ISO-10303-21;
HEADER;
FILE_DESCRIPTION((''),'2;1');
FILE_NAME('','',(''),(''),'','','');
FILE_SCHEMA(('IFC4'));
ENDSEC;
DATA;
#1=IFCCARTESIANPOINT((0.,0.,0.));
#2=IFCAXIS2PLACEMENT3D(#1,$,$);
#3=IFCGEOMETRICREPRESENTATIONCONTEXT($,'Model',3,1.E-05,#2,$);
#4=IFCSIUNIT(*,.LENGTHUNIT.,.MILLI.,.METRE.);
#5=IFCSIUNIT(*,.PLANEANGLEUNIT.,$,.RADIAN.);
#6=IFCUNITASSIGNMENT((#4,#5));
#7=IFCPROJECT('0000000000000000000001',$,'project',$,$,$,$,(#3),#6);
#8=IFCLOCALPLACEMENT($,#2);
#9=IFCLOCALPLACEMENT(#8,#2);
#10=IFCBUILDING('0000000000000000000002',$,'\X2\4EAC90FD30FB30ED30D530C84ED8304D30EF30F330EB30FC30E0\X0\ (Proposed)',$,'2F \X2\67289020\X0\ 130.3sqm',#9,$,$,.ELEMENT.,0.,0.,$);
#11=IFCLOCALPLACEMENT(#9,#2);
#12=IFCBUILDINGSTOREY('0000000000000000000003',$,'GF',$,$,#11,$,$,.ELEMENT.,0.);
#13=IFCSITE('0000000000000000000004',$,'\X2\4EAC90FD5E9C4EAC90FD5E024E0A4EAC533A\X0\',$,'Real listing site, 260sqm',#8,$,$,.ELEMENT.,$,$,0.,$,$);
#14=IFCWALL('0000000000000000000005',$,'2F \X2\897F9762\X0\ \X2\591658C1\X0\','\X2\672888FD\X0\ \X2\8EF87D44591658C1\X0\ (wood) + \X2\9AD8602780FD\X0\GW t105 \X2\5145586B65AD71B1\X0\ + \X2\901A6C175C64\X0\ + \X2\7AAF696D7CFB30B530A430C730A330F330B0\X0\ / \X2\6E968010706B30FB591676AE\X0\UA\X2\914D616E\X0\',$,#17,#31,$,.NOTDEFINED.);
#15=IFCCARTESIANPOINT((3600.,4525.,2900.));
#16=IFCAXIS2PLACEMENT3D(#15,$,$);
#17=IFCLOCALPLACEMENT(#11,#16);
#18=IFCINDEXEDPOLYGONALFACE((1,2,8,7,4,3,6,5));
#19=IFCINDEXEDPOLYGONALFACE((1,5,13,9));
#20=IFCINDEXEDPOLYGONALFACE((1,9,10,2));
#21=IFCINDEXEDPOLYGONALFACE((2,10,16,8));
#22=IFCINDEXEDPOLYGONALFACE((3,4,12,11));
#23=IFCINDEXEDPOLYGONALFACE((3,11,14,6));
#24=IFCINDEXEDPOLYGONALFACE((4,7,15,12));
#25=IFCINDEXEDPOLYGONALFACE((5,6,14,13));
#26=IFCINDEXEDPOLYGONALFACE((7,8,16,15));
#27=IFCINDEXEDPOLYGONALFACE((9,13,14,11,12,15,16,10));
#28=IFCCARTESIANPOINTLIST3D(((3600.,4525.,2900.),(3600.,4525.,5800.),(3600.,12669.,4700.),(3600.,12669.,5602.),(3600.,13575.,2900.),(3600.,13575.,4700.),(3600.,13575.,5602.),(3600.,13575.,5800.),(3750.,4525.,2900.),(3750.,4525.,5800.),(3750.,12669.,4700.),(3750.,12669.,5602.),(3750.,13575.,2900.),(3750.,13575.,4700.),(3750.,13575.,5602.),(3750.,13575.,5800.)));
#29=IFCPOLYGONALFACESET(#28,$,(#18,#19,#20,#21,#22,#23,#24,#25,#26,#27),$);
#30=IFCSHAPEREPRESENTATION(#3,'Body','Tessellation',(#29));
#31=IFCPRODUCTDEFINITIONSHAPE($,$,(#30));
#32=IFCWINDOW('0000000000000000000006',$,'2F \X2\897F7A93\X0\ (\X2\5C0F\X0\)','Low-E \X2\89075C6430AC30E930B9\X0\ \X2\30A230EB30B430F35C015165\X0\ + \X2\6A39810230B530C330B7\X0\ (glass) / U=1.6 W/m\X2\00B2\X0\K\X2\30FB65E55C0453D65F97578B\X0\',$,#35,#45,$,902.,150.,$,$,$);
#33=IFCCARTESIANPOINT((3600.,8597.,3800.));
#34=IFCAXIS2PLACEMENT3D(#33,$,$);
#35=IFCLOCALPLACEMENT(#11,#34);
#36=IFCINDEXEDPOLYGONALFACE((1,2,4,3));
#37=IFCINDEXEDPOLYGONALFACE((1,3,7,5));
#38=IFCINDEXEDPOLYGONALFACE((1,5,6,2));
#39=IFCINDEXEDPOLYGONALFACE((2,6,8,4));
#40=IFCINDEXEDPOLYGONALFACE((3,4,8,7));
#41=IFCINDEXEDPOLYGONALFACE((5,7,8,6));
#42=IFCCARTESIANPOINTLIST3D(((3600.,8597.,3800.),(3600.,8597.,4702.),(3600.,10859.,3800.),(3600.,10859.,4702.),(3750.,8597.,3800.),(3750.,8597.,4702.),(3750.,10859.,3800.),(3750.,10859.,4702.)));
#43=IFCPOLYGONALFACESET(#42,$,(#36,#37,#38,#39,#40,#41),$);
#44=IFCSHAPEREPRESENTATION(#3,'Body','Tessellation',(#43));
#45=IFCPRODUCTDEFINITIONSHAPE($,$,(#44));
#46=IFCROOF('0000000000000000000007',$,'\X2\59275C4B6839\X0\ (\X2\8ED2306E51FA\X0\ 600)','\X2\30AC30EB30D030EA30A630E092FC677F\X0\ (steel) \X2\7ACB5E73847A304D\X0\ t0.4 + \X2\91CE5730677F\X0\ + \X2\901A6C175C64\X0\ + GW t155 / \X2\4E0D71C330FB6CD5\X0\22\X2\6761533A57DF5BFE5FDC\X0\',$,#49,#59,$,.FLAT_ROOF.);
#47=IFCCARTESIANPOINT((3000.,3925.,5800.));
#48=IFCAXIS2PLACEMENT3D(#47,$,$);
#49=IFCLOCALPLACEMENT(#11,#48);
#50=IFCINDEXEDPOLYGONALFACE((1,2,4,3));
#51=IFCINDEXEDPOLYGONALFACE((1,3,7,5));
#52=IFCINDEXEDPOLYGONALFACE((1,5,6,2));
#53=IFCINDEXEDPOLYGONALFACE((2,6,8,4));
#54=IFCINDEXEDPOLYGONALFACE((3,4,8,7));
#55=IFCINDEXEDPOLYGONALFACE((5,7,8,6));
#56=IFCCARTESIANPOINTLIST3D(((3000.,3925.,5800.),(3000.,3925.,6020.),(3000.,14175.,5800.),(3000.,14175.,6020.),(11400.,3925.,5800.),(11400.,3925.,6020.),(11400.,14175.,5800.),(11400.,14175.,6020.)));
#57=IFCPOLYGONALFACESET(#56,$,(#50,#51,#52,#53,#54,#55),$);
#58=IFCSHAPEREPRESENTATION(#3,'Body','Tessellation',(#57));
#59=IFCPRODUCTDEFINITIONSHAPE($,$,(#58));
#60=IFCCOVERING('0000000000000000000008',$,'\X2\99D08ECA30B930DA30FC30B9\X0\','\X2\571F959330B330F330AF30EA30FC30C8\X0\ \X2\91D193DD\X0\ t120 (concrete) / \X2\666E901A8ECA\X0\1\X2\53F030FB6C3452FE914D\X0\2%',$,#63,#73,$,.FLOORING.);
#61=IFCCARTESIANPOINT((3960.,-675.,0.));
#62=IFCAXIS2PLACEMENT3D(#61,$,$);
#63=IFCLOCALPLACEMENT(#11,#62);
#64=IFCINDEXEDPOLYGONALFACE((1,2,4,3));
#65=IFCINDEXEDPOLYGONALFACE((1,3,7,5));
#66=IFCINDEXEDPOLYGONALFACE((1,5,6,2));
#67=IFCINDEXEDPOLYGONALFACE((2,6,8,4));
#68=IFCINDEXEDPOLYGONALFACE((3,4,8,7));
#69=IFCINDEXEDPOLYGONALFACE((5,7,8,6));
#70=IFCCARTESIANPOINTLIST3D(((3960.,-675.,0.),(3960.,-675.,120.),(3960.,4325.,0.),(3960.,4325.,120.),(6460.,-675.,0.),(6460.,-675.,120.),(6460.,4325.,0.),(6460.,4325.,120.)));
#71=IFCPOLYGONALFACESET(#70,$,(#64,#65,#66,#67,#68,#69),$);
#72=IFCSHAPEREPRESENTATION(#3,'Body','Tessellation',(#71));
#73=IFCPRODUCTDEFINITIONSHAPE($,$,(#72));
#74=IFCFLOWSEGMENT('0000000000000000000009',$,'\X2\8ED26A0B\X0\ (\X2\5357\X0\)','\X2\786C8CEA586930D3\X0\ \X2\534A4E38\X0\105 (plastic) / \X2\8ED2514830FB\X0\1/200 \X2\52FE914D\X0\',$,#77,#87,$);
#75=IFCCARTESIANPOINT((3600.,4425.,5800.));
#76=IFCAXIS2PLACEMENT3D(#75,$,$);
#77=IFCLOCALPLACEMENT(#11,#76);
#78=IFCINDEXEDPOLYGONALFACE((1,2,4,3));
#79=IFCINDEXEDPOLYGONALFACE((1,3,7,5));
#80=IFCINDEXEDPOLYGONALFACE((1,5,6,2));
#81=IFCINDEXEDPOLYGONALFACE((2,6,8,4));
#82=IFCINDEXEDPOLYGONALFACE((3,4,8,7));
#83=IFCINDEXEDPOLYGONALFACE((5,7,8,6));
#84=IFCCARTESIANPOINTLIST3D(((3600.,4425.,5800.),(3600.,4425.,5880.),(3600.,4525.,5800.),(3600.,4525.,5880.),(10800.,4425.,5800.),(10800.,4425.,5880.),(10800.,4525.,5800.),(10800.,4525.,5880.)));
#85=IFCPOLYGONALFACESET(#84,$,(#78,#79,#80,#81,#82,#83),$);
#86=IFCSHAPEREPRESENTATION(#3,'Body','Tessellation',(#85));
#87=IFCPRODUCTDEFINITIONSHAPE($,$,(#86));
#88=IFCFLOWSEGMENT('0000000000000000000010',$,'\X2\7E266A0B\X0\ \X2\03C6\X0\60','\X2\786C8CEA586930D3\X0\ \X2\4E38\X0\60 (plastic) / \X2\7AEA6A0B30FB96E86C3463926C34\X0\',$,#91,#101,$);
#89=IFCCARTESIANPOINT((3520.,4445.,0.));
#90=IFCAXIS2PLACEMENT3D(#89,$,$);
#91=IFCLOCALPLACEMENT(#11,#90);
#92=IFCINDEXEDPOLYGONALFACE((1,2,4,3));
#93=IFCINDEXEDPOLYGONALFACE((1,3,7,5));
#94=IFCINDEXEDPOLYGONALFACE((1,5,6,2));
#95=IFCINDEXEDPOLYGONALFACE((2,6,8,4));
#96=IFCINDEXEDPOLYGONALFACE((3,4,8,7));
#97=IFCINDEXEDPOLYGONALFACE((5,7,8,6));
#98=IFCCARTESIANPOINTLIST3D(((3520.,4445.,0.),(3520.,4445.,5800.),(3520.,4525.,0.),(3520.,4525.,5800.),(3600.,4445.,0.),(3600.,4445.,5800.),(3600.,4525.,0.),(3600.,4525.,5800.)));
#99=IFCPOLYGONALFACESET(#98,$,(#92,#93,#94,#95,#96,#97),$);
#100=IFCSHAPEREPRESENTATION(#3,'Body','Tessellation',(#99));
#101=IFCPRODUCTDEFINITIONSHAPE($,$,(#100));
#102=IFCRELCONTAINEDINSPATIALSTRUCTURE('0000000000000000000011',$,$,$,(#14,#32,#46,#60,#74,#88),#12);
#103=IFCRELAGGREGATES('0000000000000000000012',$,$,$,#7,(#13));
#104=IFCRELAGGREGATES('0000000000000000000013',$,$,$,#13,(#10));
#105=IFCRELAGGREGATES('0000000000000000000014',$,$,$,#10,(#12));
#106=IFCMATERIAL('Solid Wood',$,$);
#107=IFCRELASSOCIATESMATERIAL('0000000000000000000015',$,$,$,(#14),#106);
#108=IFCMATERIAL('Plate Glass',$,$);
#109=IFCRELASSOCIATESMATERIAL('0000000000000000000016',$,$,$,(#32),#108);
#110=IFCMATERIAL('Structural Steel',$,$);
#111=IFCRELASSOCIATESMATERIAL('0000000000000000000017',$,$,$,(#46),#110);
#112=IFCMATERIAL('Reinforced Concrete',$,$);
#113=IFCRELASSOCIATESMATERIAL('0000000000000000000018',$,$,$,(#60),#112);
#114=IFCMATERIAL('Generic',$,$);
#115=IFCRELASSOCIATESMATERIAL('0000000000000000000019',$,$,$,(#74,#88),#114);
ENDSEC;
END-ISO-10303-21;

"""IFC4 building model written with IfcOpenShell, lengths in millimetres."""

from ifc_helpers import new_model, si_unit, frame, frame_2d, origin, place, context, project, spatial, rectangle, extrude, material, element, fill, save


model = new_model("IFC4")

# Units and contexts
model_context = context("Model", 3, precision=1e-05, world=origin())
ifc_project = project(units=[si_unit("LENGTHUNIT", "METRE", prefix="MILLI"), si_unit("PLANEANGLEUNIT", "RADIAN")], contexts=[model_context])

# Site, building, storey
site_placement = place(None, origin())
site = spatial("IfcSite", under=ifc_project, at=site_placement, Name="京都府京都市上京区", ObjectType="Real listing site, 260sqm", CompositionType="ELEMENT", RefElevation=0.0)
building_placement = place(site_placement, origin())
building = spatial("IfcBuilding", under=site, at=building_placement, Name="京都・ロフト付きワンルーム (Proposed)", ObjectType="2F 木造 130.3sqm", CompositionType="ELEMENT", ElevationOfRefHeight=0.0, ElevationOfTerrain=0.0)
storey_placement = place(building_placement, origin())
storey = spatial("IfcBuildingStorey", under=building, at=storey_placement, Name="GF", CompositionType="ELEMENT", Elevation=0.0)

# Shared definitions
ifc_material_1 = material(Name="Solid Wood")

# Shared definitions
ifc_material_2 = material(Name="Reinforced Concrete")

# Shared definitions
ifc_material_3 = material(Name="Plate Glass")

# Wall, opening, window
wall_1_placement = place(storey_placement, frame((3600.0, 4525.0, 2900.0)))
wall_1 = element("IfcWall", 1, at=wall_1_placement, inside=storey, material=ifc_material_1, Name="2F 西面 外壁", Description="木製 軸組外壁 (wood) + 高性能GW t105 充填断熱 + 通気層 + 窯業系サイディング / 準耐火・外皮UA配慮", PredefinedType="NOTDEFINED", context=model_context, shape_type="SweptSolid", body=[
    extrude(rectangle(XDim=150.0, YDim=9050.0, at=frame_2d((75.0, 4525.0))), frame((3600.0, 4525.0, 2900.0)), (0.0, 0.0, 1.0), 2900.0),
])
opening_1_placement = place(storey_placement, frame((3600.0, 8597.0, 3800.0)))
opening_1 = element("IfcOpeningElement", 2, at=opening_1_placement, cuts=wall_1, PredefinedType="NOTDEFINED", context=model_context, shape_type="SweptSolid", body=[
    extrude(rectangle(XDim=150.0, YDim=2262.0, at=frame_2d((75.0, 1131.0))), frame((3600.0, 8597.0, 3800.0)), (0.0, 0.0, 1.0), 902.0),
])
window_1_placement = place(storey_placement, frame((3600.0, 8597.0, 3800.0)))
window_1 = element("IfcWindow", 3, at=window_1_placement, inside=storey, material=ifc_material_3, Name="2F 西窓 (小)", Description="Low-E 複層ガラス アルゴン封入 + 樹脂サッシ (glass) / U=1.6 W/m²K・日射取得型", OverallHeight=902.0, OverallWidth=150.0, context=model_context, shape_type="SweptSolid", body=[
    extrude(rectangle(XDim=150.0, YDim=2262.0, at=frame_2d((75.0, 1131.0))), frame((3600.0, 8597.0, 3800.0)), (0.0, 0.0, 1.0), 902.0),
])
fill(opening_1, window_1)

# Roof
ifc_material_4 = material(Name="Structural Steel")
roof_placement = place(storey_placement, frame((3000.0, 3925.0, 5800.0)))
element("IfcRoof", 4, at=roof_placement, inside=storey, material=ifc_material_4, Name="大屋根 (軒の出 600)", Description="ガルバリウム鋼板 (steel) 立平葺き t0.4 + 野地板 + 通気層 + GW t155 / 不燃・法22条区域対応", PredefinedType="FLAT_ROOF", context=model_context, shape_type="SweptSolid", body=[
    extrude(rectangle(XDim=8400.0, YDim=10250.0, at=frame_2d((4200.0, 5125.0))), frame((3000.0, 3925.0, 5800.0)), (0.0, 0.0, 1.0), 220.0),
])

# Covering
covering_placement = place(storey_placement, frame((3960.0, -675.0, 0.0)))
element("IfcCovering", 5, at=covering_placement, inside=storey, material=ifc_material_2, Name="駐車スペース", Description="土間コンクリート 金鏝 t120 (concrete) / 普通車1台・水勾配2%", PredefinedType="FLOORING", context=model_context, shape_type="SweptSolid", body=[
    extrude(rectangle(XDim=2500.0, YDim=5000.0, at=frame_2d((1250.0, 2500.0))), frame((3960.0, -675.0, 0.0)), (0.0, 0.0, 1.0), 120.0),
])

# Flow segments
ifc_material_5 = material(Name="Generic")
flow_segment_1_placement = place(storey_placement, frame((3600.0, 4425.0, 5800.0)))
element("IfcFlowSegment", 6, at=flow_segment_1_placement, inside=storey, material=ifc_material_5, Name="軒樋 (南)", Description="硬質塩ビ 半丸105 (plastic) / 軒先・1/200 勾配", context=model_context, shape_type="SweptSolid", body=[
    extrude(rectangle(XDim=7200.0, YDim=100.0, at=frame_2d((3600.0, 50.0))), frame((3600.0, 4425.0, 5800.0)), (0.0, 0.0, 1.0), 80.0),
])
flow_segment_2_placement = place(storey_placement, frame((3520.0, 4445.0, 0.0)))
element("IfcFlowSegment", 7, at=flow_segment_2_placement, inside=storey, material=ifc_material_5, Name="縦樋 φ60", Description="硬質塩ビ 丸60 (plastic) / 竪樋・雨水排水", context=model_context, shape_type="SweptSolid", body=[
    extrude(rectangle(XDim=80.0, YDim=80.0, at=frame_2d((40.0, 40.0))), frame((3520.0, 4445.0, 0.0)), (0.0, 0.0, 1.0), 5800.0),
])

save(model, "model.ifc")
